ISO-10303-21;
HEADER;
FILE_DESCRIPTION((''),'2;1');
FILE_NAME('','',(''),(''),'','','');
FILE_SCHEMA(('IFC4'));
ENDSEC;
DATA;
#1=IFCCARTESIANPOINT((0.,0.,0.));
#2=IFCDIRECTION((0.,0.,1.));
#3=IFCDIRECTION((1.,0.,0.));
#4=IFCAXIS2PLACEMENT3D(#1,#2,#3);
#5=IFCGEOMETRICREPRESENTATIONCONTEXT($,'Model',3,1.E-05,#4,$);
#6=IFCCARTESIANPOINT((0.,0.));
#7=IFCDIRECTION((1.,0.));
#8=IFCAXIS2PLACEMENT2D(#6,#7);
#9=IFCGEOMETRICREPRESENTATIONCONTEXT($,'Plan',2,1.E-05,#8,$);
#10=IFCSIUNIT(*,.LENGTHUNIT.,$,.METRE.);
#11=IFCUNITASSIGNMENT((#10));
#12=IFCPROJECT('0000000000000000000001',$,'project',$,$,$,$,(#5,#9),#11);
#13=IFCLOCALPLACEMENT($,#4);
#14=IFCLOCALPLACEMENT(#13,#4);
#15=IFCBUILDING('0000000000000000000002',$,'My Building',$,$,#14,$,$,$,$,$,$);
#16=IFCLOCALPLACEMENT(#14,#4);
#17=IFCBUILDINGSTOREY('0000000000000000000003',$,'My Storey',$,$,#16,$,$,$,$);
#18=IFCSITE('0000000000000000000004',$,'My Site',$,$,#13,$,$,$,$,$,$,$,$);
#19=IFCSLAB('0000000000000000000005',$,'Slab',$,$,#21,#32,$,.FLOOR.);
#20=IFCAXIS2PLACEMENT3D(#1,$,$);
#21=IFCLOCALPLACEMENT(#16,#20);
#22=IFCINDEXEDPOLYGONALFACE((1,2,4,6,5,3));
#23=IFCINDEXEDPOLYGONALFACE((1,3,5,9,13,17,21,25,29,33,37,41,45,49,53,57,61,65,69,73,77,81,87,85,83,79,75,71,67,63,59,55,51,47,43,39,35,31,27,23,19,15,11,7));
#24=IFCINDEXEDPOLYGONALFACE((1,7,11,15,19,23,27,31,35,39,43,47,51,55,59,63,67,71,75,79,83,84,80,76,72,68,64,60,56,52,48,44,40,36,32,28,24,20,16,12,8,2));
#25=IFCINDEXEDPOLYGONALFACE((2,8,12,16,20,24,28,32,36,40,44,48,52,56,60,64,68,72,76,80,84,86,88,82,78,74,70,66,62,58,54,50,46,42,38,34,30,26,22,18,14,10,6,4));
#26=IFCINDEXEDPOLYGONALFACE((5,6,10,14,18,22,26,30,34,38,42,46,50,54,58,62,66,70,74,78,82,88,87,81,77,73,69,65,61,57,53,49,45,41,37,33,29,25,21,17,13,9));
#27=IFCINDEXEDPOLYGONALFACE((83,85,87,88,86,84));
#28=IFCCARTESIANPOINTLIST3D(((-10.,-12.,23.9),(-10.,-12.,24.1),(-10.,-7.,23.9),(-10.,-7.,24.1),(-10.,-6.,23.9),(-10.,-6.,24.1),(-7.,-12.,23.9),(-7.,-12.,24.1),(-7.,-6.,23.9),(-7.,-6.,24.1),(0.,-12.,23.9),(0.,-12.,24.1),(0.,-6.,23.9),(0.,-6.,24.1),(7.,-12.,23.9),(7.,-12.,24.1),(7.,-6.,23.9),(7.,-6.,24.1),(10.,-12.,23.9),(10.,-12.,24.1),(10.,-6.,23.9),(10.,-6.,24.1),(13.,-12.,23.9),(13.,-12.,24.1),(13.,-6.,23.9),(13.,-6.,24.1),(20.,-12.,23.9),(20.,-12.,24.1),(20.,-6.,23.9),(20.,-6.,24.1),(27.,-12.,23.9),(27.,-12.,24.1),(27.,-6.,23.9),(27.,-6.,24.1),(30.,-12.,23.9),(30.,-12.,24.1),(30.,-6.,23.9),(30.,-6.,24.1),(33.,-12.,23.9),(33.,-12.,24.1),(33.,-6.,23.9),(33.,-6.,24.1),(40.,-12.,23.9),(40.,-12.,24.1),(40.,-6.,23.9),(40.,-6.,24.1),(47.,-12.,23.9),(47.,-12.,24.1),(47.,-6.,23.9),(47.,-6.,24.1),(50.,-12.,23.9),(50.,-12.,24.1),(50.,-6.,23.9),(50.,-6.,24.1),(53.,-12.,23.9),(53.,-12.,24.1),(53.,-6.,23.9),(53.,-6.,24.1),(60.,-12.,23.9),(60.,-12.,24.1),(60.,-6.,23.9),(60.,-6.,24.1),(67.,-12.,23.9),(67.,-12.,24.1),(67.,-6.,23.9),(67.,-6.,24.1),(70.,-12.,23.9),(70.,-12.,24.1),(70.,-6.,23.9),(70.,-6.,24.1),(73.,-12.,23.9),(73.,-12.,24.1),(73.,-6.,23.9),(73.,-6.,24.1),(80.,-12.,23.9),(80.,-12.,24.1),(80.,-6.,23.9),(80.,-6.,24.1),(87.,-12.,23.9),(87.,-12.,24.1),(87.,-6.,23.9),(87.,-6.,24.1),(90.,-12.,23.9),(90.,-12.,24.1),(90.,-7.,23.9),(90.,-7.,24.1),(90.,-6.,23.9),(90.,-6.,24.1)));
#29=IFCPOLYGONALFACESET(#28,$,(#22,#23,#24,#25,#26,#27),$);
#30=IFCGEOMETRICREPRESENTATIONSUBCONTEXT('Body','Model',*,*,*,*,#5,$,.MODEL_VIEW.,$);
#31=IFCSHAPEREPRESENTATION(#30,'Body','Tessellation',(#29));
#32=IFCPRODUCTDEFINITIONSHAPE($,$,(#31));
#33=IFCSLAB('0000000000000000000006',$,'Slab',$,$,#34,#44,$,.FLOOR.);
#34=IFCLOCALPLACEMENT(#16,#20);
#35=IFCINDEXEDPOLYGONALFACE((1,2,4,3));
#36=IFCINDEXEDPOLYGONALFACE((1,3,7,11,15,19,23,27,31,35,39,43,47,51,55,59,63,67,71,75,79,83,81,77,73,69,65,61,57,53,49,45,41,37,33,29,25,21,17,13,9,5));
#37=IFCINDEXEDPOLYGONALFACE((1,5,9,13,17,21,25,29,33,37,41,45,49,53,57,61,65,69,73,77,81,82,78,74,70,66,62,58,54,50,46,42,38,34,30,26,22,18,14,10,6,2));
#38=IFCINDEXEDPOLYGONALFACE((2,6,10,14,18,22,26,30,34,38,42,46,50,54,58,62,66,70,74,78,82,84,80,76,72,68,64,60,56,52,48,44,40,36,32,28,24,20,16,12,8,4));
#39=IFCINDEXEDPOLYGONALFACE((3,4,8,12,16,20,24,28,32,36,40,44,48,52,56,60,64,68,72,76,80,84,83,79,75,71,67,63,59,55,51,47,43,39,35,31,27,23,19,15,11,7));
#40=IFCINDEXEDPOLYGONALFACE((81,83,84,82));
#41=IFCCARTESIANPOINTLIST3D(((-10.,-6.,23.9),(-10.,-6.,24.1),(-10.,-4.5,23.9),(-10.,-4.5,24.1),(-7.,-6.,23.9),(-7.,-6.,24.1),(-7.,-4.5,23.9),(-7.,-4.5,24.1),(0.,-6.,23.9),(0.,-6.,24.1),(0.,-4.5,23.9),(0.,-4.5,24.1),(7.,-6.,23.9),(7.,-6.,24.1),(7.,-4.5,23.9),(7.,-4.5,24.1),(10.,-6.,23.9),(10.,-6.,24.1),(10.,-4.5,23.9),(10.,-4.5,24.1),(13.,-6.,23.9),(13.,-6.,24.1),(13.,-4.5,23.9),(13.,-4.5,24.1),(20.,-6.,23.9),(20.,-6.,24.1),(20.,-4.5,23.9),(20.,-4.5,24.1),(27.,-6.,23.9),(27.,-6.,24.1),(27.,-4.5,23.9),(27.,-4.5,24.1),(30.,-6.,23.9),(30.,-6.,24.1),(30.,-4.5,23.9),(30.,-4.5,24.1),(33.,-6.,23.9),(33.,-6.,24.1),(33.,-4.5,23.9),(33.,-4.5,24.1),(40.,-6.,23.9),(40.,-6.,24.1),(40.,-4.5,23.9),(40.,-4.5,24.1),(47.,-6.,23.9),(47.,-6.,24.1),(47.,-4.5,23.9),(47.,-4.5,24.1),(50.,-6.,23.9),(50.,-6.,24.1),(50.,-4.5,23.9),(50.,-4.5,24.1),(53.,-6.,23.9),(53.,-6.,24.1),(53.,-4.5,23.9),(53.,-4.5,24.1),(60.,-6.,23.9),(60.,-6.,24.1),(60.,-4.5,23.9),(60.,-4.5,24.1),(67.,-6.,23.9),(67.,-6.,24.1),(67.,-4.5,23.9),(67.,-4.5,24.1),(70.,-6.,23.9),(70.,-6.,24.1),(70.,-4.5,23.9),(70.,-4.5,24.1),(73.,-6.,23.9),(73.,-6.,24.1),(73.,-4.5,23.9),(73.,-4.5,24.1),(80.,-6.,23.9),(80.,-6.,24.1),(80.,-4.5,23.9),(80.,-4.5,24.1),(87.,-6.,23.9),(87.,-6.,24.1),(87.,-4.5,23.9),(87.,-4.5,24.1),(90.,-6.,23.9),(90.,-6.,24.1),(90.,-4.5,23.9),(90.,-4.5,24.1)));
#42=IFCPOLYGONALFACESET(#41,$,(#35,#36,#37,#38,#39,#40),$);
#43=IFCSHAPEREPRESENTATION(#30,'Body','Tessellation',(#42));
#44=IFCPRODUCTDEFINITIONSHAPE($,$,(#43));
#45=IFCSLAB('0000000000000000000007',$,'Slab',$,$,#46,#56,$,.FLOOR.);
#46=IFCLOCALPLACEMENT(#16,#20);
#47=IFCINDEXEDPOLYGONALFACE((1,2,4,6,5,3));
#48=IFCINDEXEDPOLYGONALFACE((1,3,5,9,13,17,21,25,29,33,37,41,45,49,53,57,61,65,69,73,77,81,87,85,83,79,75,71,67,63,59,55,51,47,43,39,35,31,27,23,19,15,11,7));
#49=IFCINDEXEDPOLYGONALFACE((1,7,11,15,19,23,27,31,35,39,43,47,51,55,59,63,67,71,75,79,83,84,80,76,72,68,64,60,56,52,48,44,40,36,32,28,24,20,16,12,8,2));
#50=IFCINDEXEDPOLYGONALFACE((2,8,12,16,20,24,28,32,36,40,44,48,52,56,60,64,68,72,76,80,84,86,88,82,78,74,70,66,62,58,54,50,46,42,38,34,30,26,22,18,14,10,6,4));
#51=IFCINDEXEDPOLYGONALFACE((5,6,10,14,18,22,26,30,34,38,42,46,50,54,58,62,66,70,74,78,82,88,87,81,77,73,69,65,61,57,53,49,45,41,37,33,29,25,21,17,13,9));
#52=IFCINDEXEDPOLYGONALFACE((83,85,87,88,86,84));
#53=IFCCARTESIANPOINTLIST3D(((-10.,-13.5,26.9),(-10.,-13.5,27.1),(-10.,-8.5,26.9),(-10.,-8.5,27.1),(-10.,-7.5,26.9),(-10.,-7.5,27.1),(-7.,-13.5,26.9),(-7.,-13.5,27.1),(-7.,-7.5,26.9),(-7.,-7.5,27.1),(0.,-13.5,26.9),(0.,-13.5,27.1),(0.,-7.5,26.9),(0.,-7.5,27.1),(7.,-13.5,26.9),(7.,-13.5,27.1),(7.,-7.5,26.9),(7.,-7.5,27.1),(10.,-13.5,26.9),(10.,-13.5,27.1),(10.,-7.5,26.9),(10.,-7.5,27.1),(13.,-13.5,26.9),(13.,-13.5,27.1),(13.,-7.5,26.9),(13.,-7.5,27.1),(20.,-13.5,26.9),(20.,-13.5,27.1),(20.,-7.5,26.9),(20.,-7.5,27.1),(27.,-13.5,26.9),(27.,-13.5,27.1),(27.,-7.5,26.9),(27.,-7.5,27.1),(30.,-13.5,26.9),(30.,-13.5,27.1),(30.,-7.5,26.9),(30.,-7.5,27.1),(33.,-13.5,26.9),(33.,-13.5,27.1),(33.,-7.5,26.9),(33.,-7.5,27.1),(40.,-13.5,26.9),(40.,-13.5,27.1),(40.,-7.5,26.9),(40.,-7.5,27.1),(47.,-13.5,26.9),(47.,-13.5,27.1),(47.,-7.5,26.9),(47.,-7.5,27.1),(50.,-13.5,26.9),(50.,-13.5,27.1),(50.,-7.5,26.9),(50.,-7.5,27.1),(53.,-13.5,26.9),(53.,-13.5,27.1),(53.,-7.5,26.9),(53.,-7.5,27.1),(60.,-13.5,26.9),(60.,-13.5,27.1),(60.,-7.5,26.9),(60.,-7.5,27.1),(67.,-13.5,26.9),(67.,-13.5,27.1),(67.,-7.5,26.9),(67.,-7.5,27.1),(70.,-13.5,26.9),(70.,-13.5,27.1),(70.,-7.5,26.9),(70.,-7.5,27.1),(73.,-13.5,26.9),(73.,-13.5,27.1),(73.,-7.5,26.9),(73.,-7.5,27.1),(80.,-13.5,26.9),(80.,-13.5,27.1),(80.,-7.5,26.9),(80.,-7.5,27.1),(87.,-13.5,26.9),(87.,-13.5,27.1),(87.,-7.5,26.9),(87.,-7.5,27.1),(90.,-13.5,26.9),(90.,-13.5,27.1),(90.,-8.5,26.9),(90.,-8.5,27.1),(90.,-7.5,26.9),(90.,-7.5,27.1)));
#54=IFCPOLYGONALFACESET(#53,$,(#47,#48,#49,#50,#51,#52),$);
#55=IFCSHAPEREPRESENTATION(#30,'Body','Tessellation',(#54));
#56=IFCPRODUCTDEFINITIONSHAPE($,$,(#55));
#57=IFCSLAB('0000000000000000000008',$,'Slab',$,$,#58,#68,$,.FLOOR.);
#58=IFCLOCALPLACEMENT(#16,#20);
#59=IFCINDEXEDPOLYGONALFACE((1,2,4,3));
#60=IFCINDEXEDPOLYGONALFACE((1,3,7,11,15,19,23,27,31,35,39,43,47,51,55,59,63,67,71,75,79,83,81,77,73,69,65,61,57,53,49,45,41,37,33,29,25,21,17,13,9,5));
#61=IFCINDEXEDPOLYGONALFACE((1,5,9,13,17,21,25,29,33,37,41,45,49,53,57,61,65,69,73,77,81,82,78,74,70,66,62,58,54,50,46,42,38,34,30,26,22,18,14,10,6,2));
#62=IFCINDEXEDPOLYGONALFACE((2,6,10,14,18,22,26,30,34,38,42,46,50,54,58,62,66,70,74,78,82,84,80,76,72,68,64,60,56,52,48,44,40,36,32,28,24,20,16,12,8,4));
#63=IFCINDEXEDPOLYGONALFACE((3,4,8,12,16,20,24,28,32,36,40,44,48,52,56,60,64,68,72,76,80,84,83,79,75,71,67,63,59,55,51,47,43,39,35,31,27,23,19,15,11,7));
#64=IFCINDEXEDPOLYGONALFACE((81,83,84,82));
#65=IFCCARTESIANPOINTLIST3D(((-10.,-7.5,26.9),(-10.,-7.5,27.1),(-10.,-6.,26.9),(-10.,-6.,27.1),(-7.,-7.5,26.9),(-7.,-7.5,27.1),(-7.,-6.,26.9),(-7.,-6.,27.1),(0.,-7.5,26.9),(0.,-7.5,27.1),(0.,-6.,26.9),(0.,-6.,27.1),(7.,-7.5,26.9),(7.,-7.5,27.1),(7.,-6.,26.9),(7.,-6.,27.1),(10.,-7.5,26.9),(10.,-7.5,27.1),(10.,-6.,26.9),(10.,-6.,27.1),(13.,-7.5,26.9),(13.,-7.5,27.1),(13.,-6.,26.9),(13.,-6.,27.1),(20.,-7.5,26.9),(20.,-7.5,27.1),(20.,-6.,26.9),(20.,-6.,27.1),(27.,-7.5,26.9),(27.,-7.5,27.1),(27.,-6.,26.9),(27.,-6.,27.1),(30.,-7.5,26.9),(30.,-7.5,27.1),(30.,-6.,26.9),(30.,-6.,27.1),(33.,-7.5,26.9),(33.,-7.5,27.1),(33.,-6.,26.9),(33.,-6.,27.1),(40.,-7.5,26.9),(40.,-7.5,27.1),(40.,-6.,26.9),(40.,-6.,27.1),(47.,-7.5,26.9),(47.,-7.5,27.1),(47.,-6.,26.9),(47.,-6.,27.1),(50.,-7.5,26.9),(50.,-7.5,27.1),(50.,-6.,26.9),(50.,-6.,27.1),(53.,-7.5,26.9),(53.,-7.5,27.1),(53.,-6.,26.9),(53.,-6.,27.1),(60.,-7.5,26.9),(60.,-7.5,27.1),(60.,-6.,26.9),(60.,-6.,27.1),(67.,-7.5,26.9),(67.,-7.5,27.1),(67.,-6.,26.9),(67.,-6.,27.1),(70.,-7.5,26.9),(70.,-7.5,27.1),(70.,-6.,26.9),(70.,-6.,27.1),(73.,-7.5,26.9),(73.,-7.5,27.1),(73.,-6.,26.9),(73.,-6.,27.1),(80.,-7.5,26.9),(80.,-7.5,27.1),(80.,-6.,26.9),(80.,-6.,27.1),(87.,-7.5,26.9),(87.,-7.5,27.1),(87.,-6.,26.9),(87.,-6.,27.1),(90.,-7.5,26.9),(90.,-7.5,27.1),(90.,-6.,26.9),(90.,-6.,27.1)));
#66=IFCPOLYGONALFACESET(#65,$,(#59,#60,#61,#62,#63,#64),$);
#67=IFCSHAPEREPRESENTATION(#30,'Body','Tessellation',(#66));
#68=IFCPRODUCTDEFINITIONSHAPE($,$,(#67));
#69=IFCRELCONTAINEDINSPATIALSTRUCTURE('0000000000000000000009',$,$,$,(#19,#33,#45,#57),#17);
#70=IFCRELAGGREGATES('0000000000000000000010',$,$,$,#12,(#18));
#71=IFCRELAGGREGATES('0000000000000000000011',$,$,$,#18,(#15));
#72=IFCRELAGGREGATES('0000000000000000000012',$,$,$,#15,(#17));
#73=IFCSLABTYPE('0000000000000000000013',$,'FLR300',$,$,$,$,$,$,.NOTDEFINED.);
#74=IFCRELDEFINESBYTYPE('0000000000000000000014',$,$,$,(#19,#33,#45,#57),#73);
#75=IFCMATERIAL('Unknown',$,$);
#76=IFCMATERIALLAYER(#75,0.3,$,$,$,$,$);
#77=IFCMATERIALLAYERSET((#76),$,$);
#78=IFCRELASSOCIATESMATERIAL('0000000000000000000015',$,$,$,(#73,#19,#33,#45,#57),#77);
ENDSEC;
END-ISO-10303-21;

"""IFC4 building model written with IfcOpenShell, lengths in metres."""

from ifc_helpers import new_model, si_unit, frame, origin, origin_with_axes, origin_2d_with_axis, place, context, subcontext, project, spatial, polyline, outline, extrude, material, layer, layer_set, layer_usage, type_object, element, save


model = new_model("IFC4")

# Units and contexts
model_context = context("Model", 3, precision=1e-05, world=origin_with_axes())
plan_context = context("Plan", 2, precision=1e-05, world=origin_2d_with_axis())
body_context = subcontext(model_context, "Body", "Model", "MODEL_VIEW")
ifc_project = project(units=[si_unit("LENGTHUNIT", "METRE")], contexts=[model_context, plan_context])

# Site, building, storey
site_placement = place(None, origin_with_axes())
site = spatial("IfcSite", under=ifc_project, at=site_placement, Name="My Site")
building_placement = place(site_placement, origin_with_axes())
building = spatial("IfcBuilding", under=site, at=building_placement, Name="My Building")
storey_placement = place(building_placement, origin_with_axes())
storey = spatial("IfcBuildingStorey", under=building, at=storey_placement, Name="My Storey")

# Slabs
ifc_material = material(Name="Unknown")
ifc_layer_1 = layer(ifc_material, 0.3)
ifc_layer_set_1 = layer_set([ifc_layer_1])
slab_type = type_object("IfcSlabType", Name="FLR300", PredefinedType="NOTDEFINED", material=ifc_layer_set_1)
ifc_layer_usage_1 = layer_usage(ifc_layer_set_1, "AXIS3", "POSITIVE", 0.0)
slab_1_placement = place(storey_placement, frame((40.0, -8.9091, 23.9), z_axis=(0.0, 0.0, 1.0), x_axis=(1.0, 0.0, 0.0)))
element("IfcSlab", 1, at=slab_1_placement, inside=storey, type_object=slab_type, material=ifc_layer_usage_1, Name="Slab", PredefinedType="FLOOR", context=body_context, shape_type="SweptSolid", body=[
    extrude(outline(polyline([(-47.0, 2.9091), (-50.0, 2.9091), (-50.0, 1.9091), (-50.0, -3.0909), (-47.0, -3.0909), (-40.0, -3.0909), (-33.0, -3.0909), (-30.0, -3.0909), (-27.0, -3.0909), (-20.0, -3.0909), (-13.0, -3.0909), (-10.0, -3.0909), (-7.0, -3.0909), (0.0, -3.0909), (7.0, -3.0909), (10.0, -3.0909), (13.0, -3.0909), (20.0, -3.0909), (27.0, -3.0909), (30.0, -3.0909), (33.0, -3.0909), (40.0, -3.0909), (47.0, -3.0909), (50.0, -3.0909), (50.0, 1.9091), (50.0, 2.9091), (47.0, 2.9091), (40.0, 2.9091), (33.0, 2.9091), (30.0, 2.9091), (27.0, 2.9091), (20.0, 2.9091), (13.0, 2.9091), (10.0, 2.9091), (7.0, 2.9091), (0.0, 2.9091), (-7.0, 2.9091), (-10.0, 2.9091), (-13.0, 2.9091), (-20.0, 2.9091), (-27.0, 2.9091), (-30.0, 2.9091), (-33.0, 2.9091), (-40.0, 2.9091), (-47.0, 2.9091)])), origin(), (0.0, 0.0, 1.0), 0.2),
])
ifc_layer_usage_2 = layer_usage(ifc_layer_set_1, "AXIS3", "POSITIVE", 0.0)
slab_2_placement = place(storey_placement, frame((40.0, -5.25, 23.9), z_axis=(0.0, 0.0, 1.0), x_axis=(1.0, 0.0, 0.0)))
element("IfcSlab", 2, at=slab_2_placement, inside=storey, type_object=slab_type, material=ifc_layer_usage_2, Name="Slab", PredefinedType="FLOOR", context=body_context, shape_type="SweptSolid", body=[
    extrude(outline(polyline([(-40.0, -0.75), (-33.0, -0.75), (-30.0, -0.75), (-27.0, -0.75), (-20.0, -0.75), (-13.0, -0.75), (-10.0, -0.75), (-7.0, -0.75), (0.0, -0.75), (7.0, -0.75), (10.0, -0.75), (13.0, -0.75), (20.0, -0.75), (27.0, -0.75), (30.0, -0.75), (33.0, -0.75), (40.0, -0.75), (47.0, -0.75), (50.0, -0.75), (50.0, 0.75), (47.0, 0.75), (40.0, 0.75), (33.0, 0.75), (30.0, 0.75), (27.0, 0.75), (20.0, 0.75), (13.0, 0.75), (10.0, 0.75), (7.0, 0.75), (0.0, 0.75), (-7.0, 0.75), (-10.0, 0.75), (-13.0, 0.75), (-20.0, 0.75), (-27.0, 0.75), (-30.0, 0.75), (-33.0, 0.75), (-40.0, 0.75), (-47.0, 0.75), (-50.0, 0.75), (-50.0, -0.75), (-47.0, -0.75), (-40.0, -0.75)])), origin(), (0.0, 0.0, 1.0), 0.2),
])
ifc_layer_usage_3 = layer_usage(ifc_layer_set_1, "AXIS3", "POSITIVE", 0.0)
slab_3_placement = place(storey_placement, frame((40.0, -10.4091, 26.9), z_axis=(0.0, 0.0, 1.0), x_axis=(1.0, 0.0, 0.0)))
element("IfcSlab", 3, at=slab_3_placement, inside=storey, type_object=slab_type, material=ifc_layer_usage_3, Name="Slab", PredefinedType="FLOOR", context=body_context, shape_type="SweptSolid", body=[
    extrude(outline(polyline([(-47.0, 2.9091), (-50.0, 2.9091), (-50.0, 1.9091), (-50.0, -3.0909), (-47.0, -3.0909), (-40.0, -3.0909), (-33.0, -3.0909), (-30.0, -3.0909), (-27.0, -3.0909), (-20.0, -3.0909), (-13.0, -3.0909), (-10.0, -3.0909), (-7.0, -3.0909), (0.0, -3.0909), (7.0, -3.0909), (10.0, -3.0909), (13.0, -3.0909), (20.0, -3.0909), (27.0, -3.0909), (30.0, -3.0909), (33.0, -3.0909), (40.0, -3.0909), (47.0, -3.0909), (50.0, -3.0909), (50.0, 1.9091), (50.0, 2.9091), (47.0, 2.9091), (40.0, 2.9091), (33.0, 2.9091), (30.0, 2.9091), (27.0, 2.9091), (20.0, 2.9091), (13.0, 2.9091), (10.0, 2.9091), (7.0, 2.9091), (0.0, 2.9091), (-7.0, 2.9091), (-10.0, 2.9091), (-13.0, 2.9091), (-20.0, 2.9091), (-27.0, 2.9091), (-30.0, 2.9091), (-33.0, 2.9091), (-40.0, 2.9091), (-47.0, 2.9091)])), origin(), (0.0, 0.0, 1.0), 0.2),
])
ifc_layer_usage_4 = layer_usage(ifc_layer_set_1, "AXIS3", "POSITIVE", 0.0)
slab_4_placement = place(storey_placement, frame((40.0, -6.75, 26.9), z_axis=(0.0, 0.0, 1.0), x_axis=(1.0, 0.0, 0.0)))
element("IfcSlab", 4, at=slab_4_placement, inside=storey, type_object=slab_type, material=ifc_layer_usage_4, Name="Slab", PredefinedType="FLOOR", context=body_context, shape_type="SweptSolid", body=[
    extrude(outline(polyline([(-40.0, -0.75), (-33.0, -0.75), (-30.0, -0.75), (-27.0, -0.75), (-20.0, -0.75), (-13.0, -0.75), (-10.0, -0.75), (-7.0, -0.75), (0.0, -0.75), (7.0, -0.75), (10.0, -0.75), (13.0, -0.75), (20.0, -0.75), (27.0, -0.75), (30.0, -0.75), (33.0, -0.75), (40.0, -0.75), (47.0, -0.75), (50.0, -0.75), (50.0, 0.75), (47.0, 0.75), (40.0, 0.75), (33.0, 0.75), (30.0, 0.75), (27.0, 0.75), (20.0, 0.75), (13.0, 0.75), (10.0, 0.75), (7.0, 0.75), (0.0, 0.75), (-7.0, 0.75), (-10.0, 0.75), (-13.0, 0.75), (-20.0, 0.75), (-27.0, 0.75), (-30.0, 0.75), (-33.0, 0.75), (-40.0, 0.75), (-47.0, 0.75), (-50.0, 0.75), (-50.0, -0.75), (-47.0, -0.75), (-40.0, -0.75)])), origin(), (0.0, 0.0, 1.0), 0.2),
])

save(model, "model.ifc")
